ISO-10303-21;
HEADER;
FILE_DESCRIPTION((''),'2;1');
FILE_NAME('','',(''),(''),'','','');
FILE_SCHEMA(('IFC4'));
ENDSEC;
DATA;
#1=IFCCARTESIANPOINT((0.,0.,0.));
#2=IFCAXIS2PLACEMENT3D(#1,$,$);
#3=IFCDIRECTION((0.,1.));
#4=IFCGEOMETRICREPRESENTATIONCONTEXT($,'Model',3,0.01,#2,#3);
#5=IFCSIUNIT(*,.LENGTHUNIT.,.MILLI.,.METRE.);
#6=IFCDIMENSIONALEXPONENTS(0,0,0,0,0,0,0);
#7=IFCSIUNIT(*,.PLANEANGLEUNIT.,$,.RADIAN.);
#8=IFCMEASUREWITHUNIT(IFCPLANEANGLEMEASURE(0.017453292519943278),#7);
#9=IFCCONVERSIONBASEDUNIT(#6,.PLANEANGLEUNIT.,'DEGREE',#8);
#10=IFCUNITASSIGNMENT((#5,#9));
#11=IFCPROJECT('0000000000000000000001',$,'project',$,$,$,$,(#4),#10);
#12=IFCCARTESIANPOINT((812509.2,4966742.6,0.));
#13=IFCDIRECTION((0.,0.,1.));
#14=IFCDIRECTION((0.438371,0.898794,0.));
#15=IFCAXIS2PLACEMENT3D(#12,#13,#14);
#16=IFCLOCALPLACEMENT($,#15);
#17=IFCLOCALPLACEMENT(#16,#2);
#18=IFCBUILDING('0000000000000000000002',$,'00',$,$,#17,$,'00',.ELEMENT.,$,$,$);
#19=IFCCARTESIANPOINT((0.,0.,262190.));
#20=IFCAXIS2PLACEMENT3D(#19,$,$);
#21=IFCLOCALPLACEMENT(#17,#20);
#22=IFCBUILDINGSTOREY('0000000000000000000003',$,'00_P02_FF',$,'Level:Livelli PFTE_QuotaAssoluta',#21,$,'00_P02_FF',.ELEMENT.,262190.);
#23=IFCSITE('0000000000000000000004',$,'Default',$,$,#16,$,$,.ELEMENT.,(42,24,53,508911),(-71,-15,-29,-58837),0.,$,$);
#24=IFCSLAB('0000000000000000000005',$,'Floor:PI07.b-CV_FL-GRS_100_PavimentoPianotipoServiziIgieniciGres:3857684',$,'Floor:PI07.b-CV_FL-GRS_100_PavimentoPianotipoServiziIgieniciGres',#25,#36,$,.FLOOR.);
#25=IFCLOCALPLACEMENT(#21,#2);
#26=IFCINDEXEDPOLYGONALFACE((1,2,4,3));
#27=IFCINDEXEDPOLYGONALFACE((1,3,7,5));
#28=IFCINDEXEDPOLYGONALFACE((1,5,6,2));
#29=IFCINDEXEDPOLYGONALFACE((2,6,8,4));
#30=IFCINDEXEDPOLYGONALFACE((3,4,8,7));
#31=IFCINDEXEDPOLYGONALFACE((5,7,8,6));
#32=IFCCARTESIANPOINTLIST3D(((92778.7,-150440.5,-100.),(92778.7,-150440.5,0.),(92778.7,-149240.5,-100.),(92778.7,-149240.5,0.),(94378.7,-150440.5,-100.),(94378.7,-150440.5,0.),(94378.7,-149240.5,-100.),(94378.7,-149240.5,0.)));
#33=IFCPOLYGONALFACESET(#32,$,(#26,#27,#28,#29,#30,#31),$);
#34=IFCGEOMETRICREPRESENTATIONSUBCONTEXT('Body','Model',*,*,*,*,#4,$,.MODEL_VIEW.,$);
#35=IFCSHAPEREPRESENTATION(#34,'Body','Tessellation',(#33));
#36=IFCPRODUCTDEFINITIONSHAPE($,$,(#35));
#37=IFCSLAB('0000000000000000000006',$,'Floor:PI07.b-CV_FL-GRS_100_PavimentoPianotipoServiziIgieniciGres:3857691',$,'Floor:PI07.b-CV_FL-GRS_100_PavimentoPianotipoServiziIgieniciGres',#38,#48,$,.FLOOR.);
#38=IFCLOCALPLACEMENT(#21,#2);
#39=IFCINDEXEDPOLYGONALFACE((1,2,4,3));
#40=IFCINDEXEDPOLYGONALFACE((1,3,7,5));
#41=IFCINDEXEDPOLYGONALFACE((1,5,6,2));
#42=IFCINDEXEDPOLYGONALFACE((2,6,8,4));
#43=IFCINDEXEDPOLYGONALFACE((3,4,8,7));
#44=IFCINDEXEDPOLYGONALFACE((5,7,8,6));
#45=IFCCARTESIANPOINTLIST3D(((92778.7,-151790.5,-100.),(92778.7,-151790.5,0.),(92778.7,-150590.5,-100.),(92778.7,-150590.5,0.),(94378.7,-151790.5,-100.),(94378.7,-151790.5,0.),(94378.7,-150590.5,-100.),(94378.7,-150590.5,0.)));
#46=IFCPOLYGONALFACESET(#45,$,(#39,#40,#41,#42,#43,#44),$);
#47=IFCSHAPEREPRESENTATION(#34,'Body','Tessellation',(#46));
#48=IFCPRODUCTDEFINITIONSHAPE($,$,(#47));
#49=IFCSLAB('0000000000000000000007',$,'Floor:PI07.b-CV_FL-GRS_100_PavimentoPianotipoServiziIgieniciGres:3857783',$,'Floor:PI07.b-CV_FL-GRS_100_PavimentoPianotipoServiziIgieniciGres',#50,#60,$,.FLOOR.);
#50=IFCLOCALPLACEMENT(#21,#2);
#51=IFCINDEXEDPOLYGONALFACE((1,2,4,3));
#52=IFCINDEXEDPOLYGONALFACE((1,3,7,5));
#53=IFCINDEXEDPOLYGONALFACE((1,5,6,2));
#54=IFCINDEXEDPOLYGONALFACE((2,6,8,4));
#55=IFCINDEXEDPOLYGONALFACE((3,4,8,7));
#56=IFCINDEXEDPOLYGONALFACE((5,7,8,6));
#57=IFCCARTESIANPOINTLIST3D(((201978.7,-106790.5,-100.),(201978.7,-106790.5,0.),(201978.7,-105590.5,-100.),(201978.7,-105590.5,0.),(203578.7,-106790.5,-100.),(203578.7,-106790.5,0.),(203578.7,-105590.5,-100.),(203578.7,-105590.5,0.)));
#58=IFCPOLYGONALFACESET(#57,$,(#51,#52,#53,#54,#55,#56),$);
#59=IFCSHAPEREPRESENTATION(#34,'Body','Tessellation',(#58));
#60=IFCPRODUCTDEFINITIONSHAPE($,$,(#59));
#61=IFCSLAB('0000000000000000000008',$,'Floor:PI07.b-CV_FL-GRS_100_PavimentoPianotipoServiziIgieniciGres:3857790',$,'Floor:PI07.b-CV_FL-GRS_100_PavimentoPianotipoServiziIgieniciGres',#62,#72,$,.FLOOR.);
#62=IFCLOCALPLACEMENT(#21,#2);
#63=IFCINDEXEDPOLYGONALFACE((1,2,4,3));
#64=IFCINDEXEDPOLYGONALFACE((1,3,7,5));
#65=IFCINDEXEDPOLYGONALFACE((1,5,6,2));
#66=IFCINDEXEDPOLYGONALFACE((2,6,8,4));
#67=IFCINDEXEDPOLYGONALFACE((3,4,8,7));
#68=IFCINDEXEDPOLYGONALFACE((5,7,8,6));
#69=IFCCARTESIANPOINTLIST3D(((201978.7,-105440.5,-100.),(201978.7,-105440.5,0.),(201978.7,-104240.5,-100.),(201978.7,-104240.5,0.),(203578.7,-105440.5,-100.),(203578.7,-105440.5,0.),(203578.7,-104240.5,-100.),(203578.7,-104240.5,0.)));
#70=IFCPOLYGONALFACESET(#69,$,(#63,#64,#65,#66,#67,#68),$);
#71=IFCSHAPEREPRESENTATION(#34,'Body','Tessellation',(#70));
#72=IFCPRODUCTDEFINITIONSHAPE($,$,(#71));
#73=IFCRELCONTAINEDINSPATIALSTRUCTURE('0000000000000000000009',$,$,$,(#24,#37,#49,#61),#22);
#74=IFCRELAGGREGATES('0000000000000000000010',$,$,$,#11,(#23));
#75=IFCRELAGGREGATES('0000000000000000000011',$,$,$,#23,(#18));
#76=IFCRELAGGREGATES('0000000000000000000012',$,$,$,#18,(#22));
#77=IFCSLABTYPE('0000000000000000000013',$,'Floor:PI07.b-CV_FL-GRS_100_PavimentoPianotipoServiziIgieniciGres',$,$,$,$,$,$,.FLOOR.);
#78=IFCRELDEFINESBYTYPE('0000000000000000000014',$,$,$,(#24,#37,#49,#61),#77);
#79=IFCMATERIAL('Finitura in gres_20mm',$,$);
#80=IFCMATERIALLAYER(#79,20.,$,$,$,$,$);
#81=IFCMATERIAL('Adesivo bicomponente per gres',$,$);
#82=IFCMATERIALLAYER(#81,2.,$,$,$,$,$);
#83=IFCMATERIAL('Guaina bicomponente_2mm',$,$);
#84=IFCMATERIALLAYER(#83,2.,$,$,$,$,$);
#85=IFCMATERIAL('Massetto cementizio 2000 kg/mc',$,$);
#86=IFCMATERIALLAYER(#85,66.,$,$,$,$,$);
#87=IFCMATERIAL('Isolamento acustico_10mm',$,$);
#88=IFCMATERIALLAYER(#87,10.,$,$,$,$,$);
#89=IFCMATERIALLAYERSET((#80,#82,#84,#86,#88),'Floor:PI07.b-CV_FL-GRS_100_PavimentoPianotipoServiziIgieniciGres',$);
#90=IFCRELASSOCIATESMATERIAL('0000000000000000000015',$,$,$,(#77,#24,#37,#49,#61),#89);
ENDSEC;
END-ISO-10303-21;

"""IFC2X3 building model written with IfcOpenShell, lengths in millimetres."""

from ifc_helpers import new_model, entity, si_unit, converted_unit, direction, frame, frame_2d, origin, origin_2d_with_axis, place, context, subcontext, project, spatial, rectangle, extrude, material, layer, layer_set, layer_usage, type_object, element, save


model = new_model("IFC2X3")

# Units and contexts
model_context = context("Model", 3, precision=0.01, world=origin(), true_north=direction((0.0, 1.0)))
body_context = subcontext(model_context, "Body", "Model", "MODEL_VIEW")
ifc_project = project(units=[si_unit("LENGTHUNIT", "METRE", prefix="MILLI"), converted_unit("PLANEANGLEUNIT", "DEGREE", entity("IfcPlaneAngleMeasure", 0.017453292519943278), si_unit("PLANEANGLEUNIT", "RADIAN"), dimensions=[0, 0, 0, 0, 0, 0, 0])], contexts=[model_context])

# Site, building, storey
site_placement = place(None, frame((812509.2, 4966742.6, 0.0), z_axis=(0.0, 0.0, 1.0), x_axis=(0.438371, 0.898794, 0.0)))
site = spatial("IfcSite", under=ifc_project, at=site_placement, Name="Default", CompositionType="ELEMENT", RefLatitude=(42, 24, 53, 508911), RefLongitude=(-71, -15, -29, -58837), RefElevation=0.0)
building_placement = place(site_placement, origin())
building = spatial("IfcBuilding", under=site, at=building_placement, Name="00", LongName="00", CompositionType="ELEMENT")
storey_placement = place(building_placement, frame((0.0, 0.0, 262190.0)))
storey = spatial("IfcBuildingStorey", under=building, at=storey_placement, Name="00_P02_FF", ObjectType="Level:Livelli PFTE_QuotaAssoluta", LongName="00_P02_FF", CompositionType="ELEMENT", Elevation=262190.0)

# Slabs
ifc_material_1 = material(Name="Massetto cementizio 2000 kg/mc")
ifc_material_2 = material(Name="Isolamento acustico_10mm")
ifc_material_3 = material(Name="Finitura in gres_20mm")
ifc_layer_1 = layer(ifc_material_3, 20.0)
ifc_material_4 = material(Name="Adesivo bicomponente per gres")
ifc_layer_2 = layer(ifc_material_4, 2.0)
ifc_material_5 = material(Name="Guaina bicomponente_2mm")
ifc_layer_3 = layer(ifc_material_5, 2.0)
ifc_layer_4 = layer(ifc_material_1, 66.0)
ifc_layer_5 = layer(ifc_material_2, 10.0)
ifc_layer_set_1 = layer_set([ifc_layer_1, ifc_layer_2, ifc_layer_3, ifc_layer_4, ifc_layer_5], Name="Floor:PI07.b-CV_FL-GRS_100_PavimentoPianotipoServiziIgieniciGres")
slab_type_1 = type_object("IfcSlabType", Name="Floor:PI07.b-CV_FL-GRS_100_PavimentoPianotipoServiziIgieniciGres", PredefinedType="FLOOR", material=ifc_layer_set_1)
ifc_layer_usage_1 = layer_usage(ifc_layer_set_1, "AXIS3", "POSITIVE", 0.0)
slab_1_placement = place(storey_placement, origin())
element("IfcSlab", 1, at=slab_1_placement, inside=storey, type_object=slab_type_1, material=ifc_layer_usage_1, Name="Floor:PI07.b-CV_FL-GRS_100_PavimentoPianotipoServiziIgieniciGres:3857684", ObjectType="Floor:PI07.b-CV_FL-GRS_100_PavimentoPianotipoServiziIgieniciGres", PredefinedType="FLOOR", context=body_context, shape_type="SweptSolid", body=[
    extrude(rectangle(XDim=1200.0, YDim=1600.0, at=frame_2d((0.0, 0.0), x_axis=(1.0, 0.0))), frame((93578.7, -149840.5, 0.0), z_axis=(0.0, 0.0, -1.0), x_axis=(0.0, 1.0, 0.0)), (0.0, 0.0, 1.0), 100.0),
])
ifc_layer_usage_2 = layer_usage(ifc_layer_set_1, "AXIS3", "POSITIVE", 0.0)
slab_2_placement = place(storey_placement, origin())
element("IfcSlab", 2, at=slab_2_placement, inside=storey, type_object=slab_type_1, material=ifc_layer_usage_2, Name="Floor:PI07.b-CV_FL-GRS_100_PavimentoPianotipoServiziIgieniciGres:3857691", ObjectType="Floor:PI07.b-CV_FL-GRS_100_PavimentoPianotipoServiziIgieniciGres", PredefinedType="FLOOR", context=body_context, shape_type="SweptSolid", body=[
    extrude(rectangle(XDim=1200.0, YDim=1600.0, at=frame_2d((0.0, 0.0), x_axis=(1.0, 0.0))), frame((93578.7, -151190.5, 0.0), z_axis=(0.0, 0.0, -1.0), x_axis=(0.0, 1.0, 0.0)), (0.0, 0.0, 1.0), 100.0),
])
ifc_layer_usage_3 = layer_usage(ifc_layer_set_1, "AXIS3", "POSITIVE", 0.0)
slab_3_placement = place(storey_placement, origin())
element("IfcSlab", 3, at=slab_3_placement, inside=storey, type_object=slab_type_1, material=ifc_layer_usage_3, Name="Floor:PI07.b-CV_FL-GRS_100_PavimentoPianotipoServiziIgieniciGres:3857783", ObjectType="Floor:PI07.b-CV_FL-GRS_100_PavimentoPianotipoServiziIgieniciGres", PredefinedType="FLOOR", context=body_context, shape_type="SweptSolid", body=[
    extrude(rectangle(XDim=1200.0, YDim=1600.0, at=origin_2d_with_axis()), frame((202778.7, -106190.5, 0.0), z_axis=(0.0, 0.0, -1.0), x_axis=(0.0, 1.0, 0.0)), (0.0, 0.0, 1.0), 100.0),
])
ifc_layer_usage_4 = layer_usage(ifc_layer_set_1, "AXIS3", "POSITIVE", 0.0)
slab_4_placement = place(storey_placement, origin())
element("IfcSlab", 4, at=slab_4_placement, inside=storey, type_object=slab_type_1, material=ifc_layer_usage_4, Name="Floor:PI07.b-CV_FL-GRS_100_PavimentoPianotipoServiziIgieniciGres:3857790", ObjectType="Floor:PI07.b-CV_FL-GRS_100_PavimentoPianotipoServiziIgieniciGres", PredefinedType="FLOOR", context=body_context, shape_type="SweptSolid", body=[
    extrude(rectangle(XDim=1200.0, YDim=1600.0, at=frame_2d((0.0, 0.0), x_axis=(1.0, 0.0))), frame((202778.7, -104840.5, 0.0), z_axis=(0.0, 0.0, -1.0), x_axis=(0.0, 1.0, 0.0)), (0.0, 0.0, 1.0), 100.0),
])

save(model, "model.ifc")
